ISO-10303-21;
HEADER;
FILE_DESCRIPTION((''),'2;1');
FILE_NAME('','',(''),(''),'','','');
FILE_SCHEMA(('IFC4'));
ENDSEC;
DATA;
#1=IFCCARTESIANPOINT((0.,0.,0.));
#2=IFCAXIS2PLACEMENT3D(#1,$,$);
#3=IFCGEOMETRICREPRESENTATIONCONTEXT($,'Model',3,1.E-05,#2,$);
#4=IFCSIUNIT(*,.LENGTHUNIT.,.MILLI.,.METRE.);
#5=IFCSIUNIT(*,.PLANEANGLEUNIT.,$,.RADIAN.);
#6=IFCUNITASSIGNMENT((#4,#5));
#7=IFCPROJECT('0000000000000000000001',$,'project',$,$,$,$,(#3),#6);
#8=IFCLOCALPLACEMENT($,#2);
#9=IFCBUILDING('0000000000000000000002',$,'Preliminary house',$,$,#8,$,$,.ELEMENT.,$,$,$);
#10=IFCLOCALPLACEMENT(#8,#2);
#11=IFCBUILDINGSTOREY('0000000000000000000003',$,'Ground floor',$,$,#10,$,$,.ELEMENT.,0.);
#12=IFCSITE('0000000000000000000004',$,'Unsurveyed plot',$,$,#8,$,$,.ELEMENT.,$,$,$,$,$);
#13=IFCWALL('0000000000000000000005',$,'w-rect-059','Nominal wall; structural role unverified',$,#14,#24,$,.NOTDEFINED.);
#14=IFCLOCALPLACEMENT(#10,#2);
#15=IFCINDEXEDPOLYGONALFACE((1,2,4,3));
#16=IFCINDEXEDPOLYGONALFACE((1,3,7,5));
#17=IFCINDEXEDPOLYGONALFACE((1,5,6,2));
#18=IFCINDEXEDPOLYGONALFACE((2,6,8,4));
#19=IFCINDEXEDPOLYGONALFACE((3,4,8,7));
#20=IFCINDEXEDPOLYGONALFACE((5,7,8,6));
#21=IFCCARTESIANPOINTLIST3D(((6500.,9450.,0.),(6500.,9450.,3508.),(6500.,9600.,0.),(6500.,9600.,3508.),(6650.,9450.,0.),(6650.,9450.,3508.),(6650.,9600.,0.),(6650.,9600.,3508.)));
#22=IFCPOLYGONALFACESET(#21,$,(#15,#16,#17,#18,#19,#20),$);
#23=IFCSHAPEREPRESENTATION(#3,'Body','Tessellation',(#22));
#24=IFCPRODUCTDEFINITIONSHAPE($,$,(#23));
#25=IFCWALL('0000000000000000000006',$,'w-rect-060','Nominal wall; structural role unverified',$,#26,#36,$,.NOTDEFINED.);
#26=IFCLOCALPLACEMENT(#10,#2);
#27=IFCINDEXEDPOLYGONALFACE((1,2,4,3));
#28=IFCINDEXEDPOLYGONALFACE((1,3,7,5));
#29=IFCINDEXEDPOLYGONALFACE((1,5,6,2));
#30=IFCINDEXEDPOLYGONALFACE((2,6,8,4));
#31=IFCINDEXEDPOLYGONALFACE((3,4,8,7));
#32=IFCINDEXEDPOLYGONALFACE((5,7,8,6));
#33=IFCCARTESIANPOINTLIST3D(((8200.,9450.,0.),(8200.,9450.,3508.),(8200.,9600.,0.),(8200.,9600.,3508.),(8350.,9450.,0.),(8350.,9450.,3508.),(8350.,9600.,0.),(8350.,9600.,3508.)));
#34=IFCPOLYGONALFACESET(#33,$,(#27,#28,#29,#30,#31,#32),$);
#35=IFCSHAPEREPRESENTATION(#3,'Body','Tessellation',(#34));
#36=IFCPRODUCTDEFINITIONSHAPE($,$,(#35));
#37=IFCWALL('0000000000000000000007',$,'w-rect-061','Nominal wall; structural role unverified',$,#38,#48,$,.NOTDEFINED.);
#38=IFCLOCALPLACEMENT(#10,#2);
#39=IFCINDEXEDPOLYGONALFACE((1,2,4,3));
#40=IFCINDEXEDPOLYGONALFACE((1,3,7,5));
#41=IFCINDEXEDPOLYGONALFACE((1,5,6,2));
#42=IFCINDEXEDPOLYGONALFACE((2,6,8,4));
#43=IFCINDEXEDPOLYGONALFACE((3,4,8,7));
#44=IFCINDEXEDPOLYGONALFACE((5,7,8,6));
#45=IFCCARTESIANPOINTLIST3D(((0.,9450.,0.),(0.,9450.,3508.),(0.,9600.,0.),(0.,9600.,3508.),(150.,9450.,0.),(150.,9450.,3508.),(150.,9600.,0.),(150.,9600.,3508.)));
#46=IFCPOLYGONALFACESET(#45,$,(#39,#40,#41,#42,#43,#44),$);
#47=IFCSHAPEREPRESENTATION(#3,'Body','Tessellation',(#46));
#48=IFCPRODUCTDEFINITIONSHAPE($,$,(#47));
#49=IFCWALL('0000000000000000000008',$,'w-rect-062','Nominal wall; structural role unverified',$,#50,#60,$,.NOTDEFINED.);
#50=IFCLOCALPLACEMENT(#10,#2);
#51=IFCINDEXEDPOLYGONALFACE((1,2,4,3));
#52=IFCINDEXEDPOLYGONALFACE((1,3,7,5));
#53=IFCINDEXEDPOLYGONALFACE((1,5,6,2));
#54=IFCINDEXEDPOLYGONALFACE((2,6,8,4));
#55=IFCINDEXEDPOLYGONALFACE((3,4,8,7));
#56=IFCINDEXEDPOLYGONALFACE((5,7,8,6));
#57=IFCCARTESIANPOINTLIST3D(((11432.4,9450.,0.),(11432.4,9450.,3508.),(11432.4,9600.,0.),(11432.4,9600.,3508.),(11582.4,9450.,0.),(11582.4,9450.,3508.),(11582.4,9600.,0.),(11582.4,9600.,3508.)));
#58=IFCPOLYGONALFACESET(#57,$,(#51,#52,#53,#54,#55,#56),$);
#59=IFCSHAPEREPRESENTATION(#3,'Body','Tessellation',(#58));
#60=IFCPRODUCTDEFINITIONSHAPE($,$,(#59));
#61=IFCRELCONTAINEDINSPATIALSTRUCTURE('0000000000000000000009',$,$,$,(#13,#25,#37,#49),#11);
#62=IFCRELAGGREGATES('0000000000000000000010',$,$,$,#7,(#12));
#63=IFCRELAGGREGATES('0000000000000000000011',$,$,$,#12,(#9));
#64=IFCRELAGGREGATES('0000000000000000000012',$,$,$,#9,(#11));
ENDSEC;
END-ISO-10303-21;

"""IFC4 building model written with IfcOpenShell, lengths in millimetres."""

from ifc_helpers import new_model, si_unit, origin, place, context, project, spatial, polyline, outline, extrude, element, save


model = new_model("IFC4")

# Units and contexts
model_context = context("Model", 3, precision=1e-05, world=origin())
ifc_project = project(units=[si_unit("LENGTHUNIT", "METRE", prefix="MILLI"), si_unit("PLANEANGLEUNIT", "RADIAN")], contexts=[model_context])

# Site, building, storey
placement_1 = place(None, origin())
site = spatial("IfcSite", under=ifc_project, at=placement_1, Name="Unsurveyed plot", CompositionType="ELEMENT")
building = spatial("IfcBuilding", under=site, at=placement_1, Name="Preliminary house", CompositionType="ELEMENT")
placement_2 = place(placement_1, origin())
storey = spatial("IfcBuildingStorey", under=building, at=placement_2, Name="Ground floor", CompositionType="ELEMENT", Elevation=0.0)

# Walls
element("IfcWall", 1, at=placement_2, inside=storey, Name="w-rect-059", Description="Nominal wall; structural role unverified", PredefinedType="NOTDEFINED", context=model_context, shape_type="SweptSolid", body=[
    extrude(outline(polyline([(6500.0, 9450.0), (6650.0, 9450.0), (6650.0, 9600.0), (6500.0, 9600.0), (6500.0, 9450.0)])), origin(), (0.0, 0.0, 1.0), 3508.0),
])
element("IfcWall", 2, at=placement_2, inside=storey, Name="w-rect-060", Description="Nominal wall; structural role unverified", PredefinedType="NOTDEFINED", context=model_context, shape_type="SweptSolid", body=[
    extrude(outline(polyline([(8200.0, 9450.0), (8350.0, 9450.0), (8350.0, 9600.0), (8200.0, 9600.0), (8200.0, 9450.0)])), origin(), (0.0, 0.0, 1.0), 3508.0),
])
element("IfcWall", 3, at=placement_2, inside=storey, Name="w-rect-061", Description="Nominal wall; structural role unverified", PredefinedType="NOTDEFINED", context=model_context, shape_type="SweptSolid", body=[
    extrude(outline(polyline([(0.0, 9450.0), (150.0, 9450.0), (150.0, 9600.0), (0.0, 9600.0), (0.0, 9450.0)])), origin(), (0.0, 0.0, 1.0), 3508.0),
])
element("IfcWall", 4, at=placement_2, inside=storey, Name="w-rect-062", Description="Nominal wall; structural role unverified", PredefinedType="NOTDEFINED", context=model_context, shape_type="SweptSolid", body=[
    extrude(outline(polyline([(11432.4, 9450.0), (11582.4, 9450.0), (11582.4, 9600.0), (11432.4, 9600.0), (11432.4, 9450.0)])), origin(), (0.0, 0.0, 1.0), 3508.0),
])

save(model, "model.ifc")
